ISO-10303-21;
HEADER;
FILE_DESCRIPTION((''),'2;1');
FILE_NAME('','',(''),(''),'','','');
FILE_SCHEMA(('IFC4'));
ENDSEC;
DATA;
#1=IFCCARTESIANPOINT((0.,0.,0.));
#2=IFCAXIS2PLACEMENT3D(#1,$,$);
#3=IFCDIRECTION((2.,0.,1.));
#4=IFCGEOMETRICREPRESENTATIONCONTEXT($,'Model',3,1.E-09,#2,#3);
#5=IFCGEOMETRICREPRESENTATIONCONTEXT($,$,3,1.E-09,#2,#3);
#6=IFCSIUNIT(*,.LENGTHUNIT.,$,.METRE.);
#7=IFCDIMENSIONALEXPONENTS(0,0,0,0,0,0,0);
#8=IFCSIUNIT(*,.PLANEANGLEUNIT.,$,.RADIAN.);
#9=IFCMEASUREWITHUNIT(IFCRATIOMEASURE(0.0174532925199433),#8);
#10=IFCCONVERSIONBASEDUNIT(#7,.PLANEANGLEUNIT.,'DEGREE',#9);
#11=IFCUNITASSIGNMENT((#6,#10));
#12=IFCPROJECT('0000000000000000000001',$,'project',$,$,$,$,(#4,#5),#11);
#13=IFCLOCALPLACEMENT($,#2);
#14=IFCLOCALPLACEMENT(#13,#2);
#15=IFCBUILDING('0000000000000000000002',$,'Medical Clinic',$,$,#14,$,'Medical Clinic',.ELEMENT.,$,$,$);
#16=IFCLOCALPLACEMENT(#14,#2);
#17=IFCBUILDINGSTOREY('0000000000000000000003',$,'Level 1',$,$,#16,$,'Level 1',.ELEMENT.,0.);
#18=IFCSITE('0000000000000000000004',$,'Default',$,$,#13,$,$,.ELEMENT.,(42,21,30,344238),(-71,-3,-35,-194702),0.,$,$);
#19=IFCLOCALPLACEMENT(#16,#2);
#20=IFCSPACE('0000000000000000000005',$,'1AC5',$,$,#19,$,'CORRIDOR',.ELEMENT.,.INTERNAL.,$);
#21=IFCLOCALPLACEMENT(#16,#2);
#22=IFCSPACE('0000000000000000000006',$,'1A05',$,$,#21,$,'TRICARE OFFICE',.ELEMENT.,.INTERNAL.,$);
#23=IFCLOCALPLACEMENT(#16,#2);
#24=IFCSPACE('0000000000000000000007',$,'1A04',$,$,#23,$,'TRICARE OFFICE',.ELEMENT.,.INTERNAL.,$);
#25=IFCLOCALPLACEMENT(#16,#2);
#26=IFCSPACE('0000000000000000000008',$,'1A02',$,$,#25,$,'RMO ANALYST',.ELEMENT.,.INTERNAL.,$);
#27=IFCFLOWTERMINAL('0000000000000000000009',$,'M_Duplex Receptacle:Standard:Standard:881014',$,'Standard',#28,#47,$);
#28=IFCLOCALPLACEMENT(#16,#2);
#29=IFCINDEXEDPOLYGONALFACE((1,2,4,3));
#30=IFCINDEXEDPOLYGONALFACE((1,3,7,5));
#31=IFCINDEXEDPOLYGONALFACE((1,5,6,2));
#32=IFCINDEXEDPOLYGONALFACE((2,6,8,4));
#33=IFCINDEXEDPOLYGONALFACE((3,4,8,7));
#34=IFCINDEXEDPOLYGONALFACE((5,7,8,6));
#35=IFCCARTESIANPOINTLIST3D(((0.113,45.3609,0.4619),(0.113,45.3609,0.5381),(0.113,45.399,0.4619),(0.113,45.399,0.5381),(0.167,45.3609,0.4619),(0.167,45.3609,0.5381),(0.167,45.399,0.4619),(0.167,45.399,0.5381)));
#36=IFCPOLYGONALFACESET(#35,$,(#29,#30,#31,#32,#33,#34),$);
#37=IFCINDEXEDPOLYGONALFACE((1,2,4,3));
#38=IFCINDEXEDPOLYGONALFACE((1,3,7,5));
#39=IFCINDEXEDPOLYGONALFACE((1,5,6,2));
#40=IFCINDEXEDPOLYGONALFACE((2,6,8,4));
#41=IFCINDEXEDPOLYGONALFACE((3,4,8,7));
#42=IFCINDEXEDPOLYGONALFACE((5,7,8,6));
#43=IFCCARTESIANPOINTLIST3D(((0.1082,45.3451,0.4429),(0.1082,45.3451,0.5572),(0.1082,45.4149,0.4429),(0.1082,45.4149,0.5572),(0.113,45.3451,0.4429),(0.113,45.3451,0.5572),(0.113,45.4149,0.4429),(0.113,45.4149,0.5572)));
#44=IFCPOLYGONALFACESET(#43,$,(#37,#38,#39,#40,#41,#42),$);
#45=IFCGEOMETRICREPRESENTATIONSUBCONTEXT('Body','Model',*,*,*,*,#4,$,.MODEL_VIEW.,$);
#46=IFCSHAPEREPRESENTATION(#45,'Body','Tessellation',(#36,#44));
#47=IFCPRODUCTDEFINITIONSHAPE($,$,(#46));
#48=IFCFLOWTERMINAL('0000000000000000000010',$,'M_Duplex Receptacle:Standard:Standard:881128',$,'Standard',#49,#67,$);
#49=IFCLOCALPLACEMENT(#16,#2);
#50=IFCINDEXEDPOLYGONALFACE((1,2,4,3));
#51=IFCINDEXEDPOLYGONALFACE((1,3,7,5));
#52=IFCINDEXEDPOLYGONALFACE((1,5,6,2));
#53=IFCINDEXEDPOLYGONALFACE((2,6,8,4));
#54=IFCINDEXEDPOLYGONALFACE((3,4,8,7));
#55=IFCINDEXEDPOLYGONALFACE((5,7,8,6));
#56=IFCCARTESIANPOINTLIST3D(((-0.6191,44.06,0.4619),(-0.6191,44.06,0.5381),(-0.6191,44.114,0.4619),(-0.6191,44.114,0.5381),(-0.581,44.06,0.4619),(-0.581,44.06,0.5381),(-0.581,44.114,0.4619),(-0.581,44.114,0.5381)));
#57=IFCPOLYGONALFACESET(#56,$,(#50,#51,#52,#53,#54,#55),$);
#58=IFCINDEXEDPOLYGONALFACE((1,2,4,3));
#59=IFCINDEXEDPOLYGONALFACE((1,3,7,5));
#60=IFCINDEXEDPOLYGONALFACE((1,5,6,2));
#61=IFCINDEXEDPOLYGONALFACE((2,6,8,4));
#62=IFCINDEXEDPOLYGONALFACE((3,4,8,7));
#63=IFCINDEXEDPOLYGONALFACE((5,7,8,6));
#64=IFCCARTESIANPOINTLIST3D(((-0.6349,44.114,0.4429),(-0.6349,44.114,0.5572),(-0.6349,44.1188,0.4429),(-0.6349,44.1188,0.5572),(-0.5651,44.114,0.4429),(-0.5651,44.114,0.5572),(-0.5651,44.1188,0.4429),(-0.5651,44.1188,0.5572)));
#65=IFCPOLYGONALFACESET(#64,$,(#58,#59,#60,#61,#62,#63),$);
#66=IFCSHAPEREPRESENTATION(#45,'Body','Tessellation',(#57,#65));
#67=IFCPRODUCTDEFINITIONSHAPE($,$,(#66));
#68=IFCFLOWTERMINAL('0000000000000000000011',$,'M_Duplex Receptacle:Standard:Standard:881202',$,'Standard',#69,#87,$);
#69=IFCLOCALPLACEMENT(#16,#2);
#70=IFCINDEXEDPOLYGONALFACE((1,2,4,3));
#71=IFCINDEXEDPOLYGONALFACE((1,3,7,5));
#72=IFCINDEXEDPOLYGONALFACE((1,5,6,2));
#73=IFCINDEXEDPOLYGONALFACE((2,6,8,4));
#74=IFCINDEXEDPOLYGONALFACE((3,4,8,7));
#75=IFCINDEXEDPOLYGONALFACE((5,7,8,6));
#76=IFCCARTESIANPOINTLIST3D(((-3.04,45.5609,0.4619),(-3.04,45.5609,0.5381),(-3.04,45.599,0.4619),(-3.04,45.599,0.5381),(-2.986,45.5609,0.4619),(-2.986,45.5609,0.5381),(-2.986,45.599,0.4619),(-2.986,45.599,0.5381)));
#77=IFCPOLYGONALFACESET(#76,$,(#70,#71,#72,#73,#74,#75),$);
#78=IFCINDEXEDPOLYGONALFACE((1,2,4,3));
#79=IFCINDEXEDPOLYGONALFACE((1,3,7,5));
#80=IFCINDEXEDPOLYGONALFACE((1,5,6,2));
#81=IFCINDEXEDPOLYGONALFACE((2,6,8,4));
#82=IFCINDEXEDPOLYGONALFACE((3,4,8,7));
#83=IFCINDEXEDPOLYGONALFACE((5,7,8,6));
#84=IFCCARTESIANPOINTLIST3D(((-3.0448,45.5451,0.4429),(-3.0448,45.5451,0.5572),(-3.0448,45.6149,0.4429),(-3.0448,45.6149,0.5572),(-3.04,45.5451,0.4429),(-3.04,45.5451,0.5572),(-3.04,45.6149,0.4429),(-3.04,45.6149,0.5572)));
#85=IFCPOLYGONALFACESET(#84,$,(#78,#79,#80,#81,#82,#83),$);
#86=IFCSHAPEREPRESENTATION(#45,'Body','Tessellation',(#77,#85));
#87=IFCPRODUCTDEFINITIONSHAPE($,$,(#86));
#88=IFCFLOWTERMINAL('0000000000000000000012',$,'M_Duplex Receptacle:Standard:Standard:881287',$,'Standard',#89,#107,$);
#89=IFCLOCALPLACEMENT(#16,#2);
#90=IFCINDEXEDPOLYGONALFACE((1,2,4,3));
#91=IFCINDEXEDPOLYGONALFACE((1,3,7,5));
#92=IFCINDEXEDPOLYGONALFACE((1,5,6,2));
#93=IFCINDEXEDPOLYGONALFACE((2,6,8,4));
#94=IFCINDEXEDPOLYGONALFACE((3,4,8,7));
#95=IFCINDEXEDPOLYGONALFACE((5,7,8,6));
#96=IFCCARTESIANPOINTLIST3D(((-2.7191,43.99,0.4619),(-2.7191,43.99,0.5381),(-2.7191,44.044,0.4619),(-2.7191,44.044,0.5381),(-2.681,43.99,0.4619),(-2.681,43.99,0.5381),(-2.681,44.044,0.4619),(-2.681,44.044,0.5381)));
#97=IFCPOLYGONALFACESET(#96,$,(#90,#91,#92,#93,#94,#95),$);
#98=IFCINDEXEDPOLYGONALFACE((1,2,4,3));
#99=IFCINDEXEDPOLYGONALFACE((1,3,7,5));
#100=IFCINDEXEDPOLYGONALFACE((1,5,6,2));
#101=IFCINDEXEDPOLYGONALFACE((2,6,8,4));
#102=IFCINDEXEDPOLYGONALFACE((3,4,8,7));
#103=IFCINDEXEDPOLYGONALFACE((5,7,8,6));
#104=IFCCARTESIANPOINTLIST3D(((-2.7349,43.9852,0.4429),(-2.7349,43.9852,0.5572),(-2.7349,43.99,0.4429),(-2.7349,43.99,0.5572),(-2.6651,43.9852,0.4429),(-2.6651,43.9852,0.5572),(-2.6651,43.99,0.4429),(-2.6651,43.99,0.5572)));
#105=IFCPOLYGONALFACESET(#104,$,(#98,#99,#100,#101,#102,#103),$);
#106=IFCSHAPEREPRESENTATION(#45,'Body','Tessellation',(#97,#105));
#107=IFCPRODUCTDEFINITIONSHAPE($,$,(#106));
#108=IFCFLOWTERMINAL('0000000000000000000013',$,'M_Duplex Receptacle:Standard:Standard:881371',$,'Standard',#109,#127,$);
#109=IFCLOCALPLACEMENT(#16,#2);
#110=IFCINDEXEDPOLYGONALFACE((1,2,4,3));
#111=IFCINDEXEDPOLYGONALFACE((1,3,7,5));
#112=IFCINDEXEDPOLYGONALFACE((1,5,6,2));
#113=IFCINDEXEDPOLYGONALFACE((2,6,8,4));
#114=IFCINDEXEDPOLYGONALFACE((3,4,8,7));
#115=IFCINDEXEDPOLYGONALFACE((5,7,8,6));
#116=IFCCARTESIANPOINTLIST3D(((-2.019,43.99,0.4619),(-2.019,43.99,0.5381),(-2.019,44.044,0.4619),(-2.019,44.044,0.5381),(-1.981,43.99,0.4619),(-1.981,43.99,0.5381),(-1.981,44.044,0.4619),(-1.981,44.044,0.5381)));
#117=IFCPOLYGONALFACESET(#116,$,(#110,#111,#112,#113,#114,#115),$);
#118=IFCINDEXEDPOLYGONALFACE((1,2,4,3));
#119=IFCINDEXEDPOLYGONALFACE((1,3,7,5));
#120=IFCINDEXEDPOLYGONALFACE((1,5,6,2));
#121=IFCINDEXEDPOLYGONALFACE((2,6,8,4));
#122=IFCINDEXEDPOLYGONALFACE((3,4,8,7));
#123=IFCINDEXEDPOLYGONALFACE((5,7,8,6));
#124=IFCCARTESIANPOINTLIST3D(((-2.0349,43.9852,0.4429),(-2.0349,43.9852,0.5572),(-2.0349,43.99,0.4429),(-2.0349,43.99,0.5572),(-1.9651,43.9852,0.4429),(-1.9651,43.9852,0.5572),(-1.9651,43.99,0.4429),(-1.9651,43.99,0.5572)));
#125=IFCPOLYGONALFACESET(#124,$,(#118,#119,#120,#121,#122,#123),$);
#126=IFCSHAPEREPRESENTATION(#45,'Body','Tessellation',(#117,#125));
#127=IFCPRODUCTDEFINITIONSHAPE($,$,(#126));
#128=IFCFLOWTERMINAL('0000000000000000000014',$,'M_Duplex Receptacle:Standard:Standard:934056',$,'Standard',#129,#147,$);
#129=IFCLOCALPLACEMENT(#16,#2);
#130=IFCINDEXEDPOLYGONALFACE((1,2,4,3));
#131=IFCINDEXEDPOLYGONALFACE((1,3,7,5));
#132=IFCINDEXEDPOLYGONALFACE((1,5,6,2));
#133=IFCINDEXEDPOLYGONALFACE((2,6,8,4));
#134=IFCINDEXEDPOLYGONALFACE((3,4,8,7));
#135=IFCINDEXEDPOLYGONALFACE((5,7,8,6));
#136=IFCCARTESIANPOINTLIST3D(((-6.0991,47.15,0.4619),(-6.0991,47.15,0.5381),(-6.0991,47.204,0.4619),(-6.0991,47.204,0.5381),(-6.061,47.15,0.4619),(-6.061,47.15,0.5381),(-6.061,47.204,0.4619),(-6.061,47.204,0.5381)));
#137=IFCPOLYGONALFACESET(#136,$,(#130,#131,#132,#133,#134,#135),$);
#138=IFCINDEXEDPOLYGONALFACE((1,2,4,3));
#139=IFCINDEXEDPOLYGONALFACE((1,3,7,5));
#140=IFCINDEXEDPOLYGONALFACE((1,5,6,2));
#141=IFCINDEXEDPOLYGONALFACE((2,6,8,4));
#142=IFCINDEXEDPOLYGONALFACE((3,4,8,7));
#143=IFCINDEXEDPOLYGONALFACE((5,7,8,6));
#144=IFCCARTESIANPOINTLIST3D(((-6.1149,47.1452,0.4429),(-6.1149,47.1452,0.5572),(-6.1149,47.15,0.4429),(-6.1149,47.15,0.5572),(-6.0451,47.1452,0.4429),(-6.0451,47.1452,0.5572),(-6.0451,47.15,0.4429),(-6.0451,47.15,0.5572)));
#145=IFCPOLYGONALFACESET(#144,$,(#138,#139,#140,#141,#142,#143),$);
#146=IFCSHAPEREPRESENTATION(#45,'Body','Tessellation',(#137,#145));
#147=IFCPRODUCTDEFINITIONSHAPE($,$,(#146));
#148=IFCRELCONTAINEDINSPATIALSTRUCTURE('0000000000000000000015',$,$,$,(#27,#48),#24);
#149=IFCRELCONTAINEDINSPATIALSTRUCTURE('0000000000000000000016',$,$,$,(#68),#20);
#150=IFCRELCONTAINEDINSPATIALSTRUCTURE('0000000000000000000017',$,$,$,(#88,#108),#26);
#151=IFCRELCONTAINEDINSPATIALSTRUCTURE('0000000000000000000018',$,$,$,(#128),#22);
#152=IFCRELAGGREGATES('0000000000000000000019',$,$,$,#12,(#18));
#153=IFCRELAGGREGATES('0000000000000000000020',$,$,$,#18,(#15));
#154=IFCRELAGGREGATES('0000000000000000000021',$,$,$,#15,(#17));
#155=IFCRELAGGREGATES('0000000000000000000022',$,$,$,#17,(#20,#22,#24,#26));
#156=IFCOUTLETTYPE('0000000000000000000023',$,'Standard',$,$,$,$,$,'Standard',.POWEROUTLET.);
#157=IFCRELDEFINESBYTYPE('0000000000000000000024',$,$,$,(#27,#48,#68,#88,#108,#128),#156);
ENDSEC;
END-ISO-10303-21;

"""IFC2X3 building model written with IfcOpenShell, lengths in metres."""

from ifc_helpers import new_model, entity, si_unit, converted_unit, direction, frame, frame_2d, origin, origin_2d_with_axis, place, context, subcontext, project, spatial, rectangle, extrude, source, transform, mapped, type_object, type_shapes, element, save


model = new_model("IFC2X3")

# Units and contexts
model_context = context("Model", 3, precision=1e-09, world=origin(), true_north=direction((2.0, 0.0, 1.0)))
context_of_model = context(None, 3, precision=1e-09, world=origin(), true_north=direction((2.0, 0.0, 1.0)))
body_context = subcontext(model_context, "Body", "Model", "MODEL_VIEW")
ifc_project = project(units=[si_unit("LENGTHUNIT", "METRE"), converted_unit("PLANEANGLEUNIT", "DEGREE", entity("IfcRatioMeasure", 0.0174532925199433), si_unit("PLANEANGLEUNIT", "RADIAN"), dimensions=[0, 0, 0, 0, 0, 0, 0])], contexts=[model_context, context_of_model])

# Site, building, storey, space
site_placement = place(None, origin())
site = spatial("IfcSite", under=ifc_project, at=site_placement, Name="Default", CompositionType="ELEMENT", RefLatitude=(42, 21, 30, 344238), RefLongitude=(-71, -3, -35, -194702), RefElevation=0.0)
building_placement = place(site_placement, origin())
building = spatial("IfcBuilding", under=site, at=building_placement, Name="Medical Clinic", LongName="Medical Clinic", CompositionType="ELEMENT")
storey_placement = place(building_placement, origin())
storey = spatial("IfcBuildingStorey", under=building, at=storey_placement, Name="Level 1", LongName="Level 1", CompositionType="ELEMENT", Elevation=0.0)
space_1_placement = place(storey_placement, origin())
space_1 = spatial("IfcSpace", under=storey, at=space_1_placement, Name="1AC5", LongName="CORRIDOR", CompositionType="ELEMENT", InteriorOrExteriorSpace="INTERNAL")

# Shared definitions
space_2_placement = place(storey_placement, origin())
space_2 = spatial("IfcSpace", under=storey, at=space_2_placement, Name="1A05", LongName="TRICARE OFFICE", CompositionType="ELEMENT", InteriorOrExteriorSpace="INTERNAL")

# Shared definitions
space_3_placement = place(storey_placement, origin())
space_3 = spatial("IfcSpace", under=storey, at=space_3_placement, Name="1A04", LongName="TRICARE OFFICE", CompositionType="ELEMENT", InteriorOrExteriorSpace="INTERNAL")

# Shared definitions
outlet_type = type_object("IfcOutletType", Name="Standard", ElementType="Standard", PredefinedType="POWEROUTLET")
shared_shape_1 = source(origin(), body_context, "Body", "SweptSolid", [
    extrude(rectangle(XDim=0.0381, YDim=0.0762, at=origin_2d_with_axis()), frame((0.0, 0.0, -0.054), z_axis=(0.0, 0.0, 1.0), x_axis=(-1.0, 0.0, 0.0)), (0.0, 0.0, 1.0), 0.054),
    extrude(rectangle(XDim=0.0698, YDim=0.1143, at=frame_2d((0.0, 0.0), x_axis=(1.0, 0.0))), frame((0.0, 0.0, 0.0), z_axis=(0.0, 0.0, 1.0), x_axis=(-1.0, 0.0, 0.0)), (0.0, 0.0, 1.0), 0.0048),
])
type_shapes(outlet_type, [shared_shape_1])

# Flow terminals
for number, where, z_axis, x_axis, name in (
    (1, (0.113, 45.38, 0.5), (-1.0, 0.0, 0.0), (0.0, -1.0, 0.0), "M_Duplex Receptacle:Standard:Standard:881014"),
    (2, (-0.6, 44.114, 0.5), (0.0, 1.0, 0.0), (-1.0, 0.0, 0.0), "M_Duplex Receptacle:Standard:Standard:881128"),
):
    element("IfcFlowTerminal", number, at=place(space_3_placement, frame(where, z_axis=z_axis, x_axis=x_axis)), inside=space_3, type_object=outlet_type, Name=name, ObjectType="Standard", context=body_context, shape_type="MappedRepresentation", body=[
        mapped(shared_shape_1, transform((0.0, 0.0, 0.0), scale=1.0)),
    ])
flow_terminal_1_placement = place(space_1_placement, frame((-3.04, 45.58, 0.5), z_axis=(-1.0, 0.0, 0.0), x_axis=(0.0, -1.0, 0.0)))
element("IfcFlowTerminal", 3, at=flow_terminal_1_placement, inside=space_1, type_object=outlet_type, Name="M_Duplex Receptacle:Standard:Standard:881202", ObjectType="Standard", context=body_context, shape_type="MappedRepresentation", body=[
    mapped(shared_shape_1, transform((0.0, 0.0, 0.0), scale=1.0)),
])

# Shared definitions
space_4_placement = place(storey_placement, origin())
space_4 = spatial("IfcSpace", under=storey, at=space_4_placement, Name="1A02", LongName="RMO ANALYST", CompositionType="ELEMENT", InteriorOrExteriorSpace="INTERNAL")

# Flow terminals
for number, where, z_axis, x_axis, name in (
    (4, (-2.7, 43.99, 0.5), (0.0, -1.0, 0.0), (1.0, 0.0, 0.0), "M_Duplex Receptacle:Standard:Standard:881287"),
    (5, (-2.0, 43.99, 0.5), (0.0, -1.0, 0.0), (1.0, 0.0, 0.0), "M_Duplex Receptacle:Standard:Standard:881371"),
):
    element("IfcFlowTerminal", number, at=place(space_4_placement, frame(where, z_axis=z_axis, x_axis=x_axis)), inside=space_4, type_object=outlet_type, Name=name, ObjectType="Standard", context=body_context, shape_type="MappedRepresentation", body=[
        mapped(shared_shape_1, transform((0.0, 0.0, 0.0), scale=1.0)),
    ])
flow_terminal_2_placement = place(space_2_placement, frame((-6.08, 47.15, 0.5), z_axis=(0.0, -1.0, 0.0), x_axis=(1.0, 0.0, 0.0)))
element("IfcFlowTerminal", 6, at=flow_terminal_2_placement, inside=space_2, type_object=outlet_type, Name="M_Duplex Receptacle:Standard:Standard:934056", ObjectType="Standard", context=body_context, shape_type="MappedRepresentation", body=[
    mapped(shared_shape_1, transform((0.0, 0.0, 0.0), scale=1.0)),
])

save(model, "model.ifc")
